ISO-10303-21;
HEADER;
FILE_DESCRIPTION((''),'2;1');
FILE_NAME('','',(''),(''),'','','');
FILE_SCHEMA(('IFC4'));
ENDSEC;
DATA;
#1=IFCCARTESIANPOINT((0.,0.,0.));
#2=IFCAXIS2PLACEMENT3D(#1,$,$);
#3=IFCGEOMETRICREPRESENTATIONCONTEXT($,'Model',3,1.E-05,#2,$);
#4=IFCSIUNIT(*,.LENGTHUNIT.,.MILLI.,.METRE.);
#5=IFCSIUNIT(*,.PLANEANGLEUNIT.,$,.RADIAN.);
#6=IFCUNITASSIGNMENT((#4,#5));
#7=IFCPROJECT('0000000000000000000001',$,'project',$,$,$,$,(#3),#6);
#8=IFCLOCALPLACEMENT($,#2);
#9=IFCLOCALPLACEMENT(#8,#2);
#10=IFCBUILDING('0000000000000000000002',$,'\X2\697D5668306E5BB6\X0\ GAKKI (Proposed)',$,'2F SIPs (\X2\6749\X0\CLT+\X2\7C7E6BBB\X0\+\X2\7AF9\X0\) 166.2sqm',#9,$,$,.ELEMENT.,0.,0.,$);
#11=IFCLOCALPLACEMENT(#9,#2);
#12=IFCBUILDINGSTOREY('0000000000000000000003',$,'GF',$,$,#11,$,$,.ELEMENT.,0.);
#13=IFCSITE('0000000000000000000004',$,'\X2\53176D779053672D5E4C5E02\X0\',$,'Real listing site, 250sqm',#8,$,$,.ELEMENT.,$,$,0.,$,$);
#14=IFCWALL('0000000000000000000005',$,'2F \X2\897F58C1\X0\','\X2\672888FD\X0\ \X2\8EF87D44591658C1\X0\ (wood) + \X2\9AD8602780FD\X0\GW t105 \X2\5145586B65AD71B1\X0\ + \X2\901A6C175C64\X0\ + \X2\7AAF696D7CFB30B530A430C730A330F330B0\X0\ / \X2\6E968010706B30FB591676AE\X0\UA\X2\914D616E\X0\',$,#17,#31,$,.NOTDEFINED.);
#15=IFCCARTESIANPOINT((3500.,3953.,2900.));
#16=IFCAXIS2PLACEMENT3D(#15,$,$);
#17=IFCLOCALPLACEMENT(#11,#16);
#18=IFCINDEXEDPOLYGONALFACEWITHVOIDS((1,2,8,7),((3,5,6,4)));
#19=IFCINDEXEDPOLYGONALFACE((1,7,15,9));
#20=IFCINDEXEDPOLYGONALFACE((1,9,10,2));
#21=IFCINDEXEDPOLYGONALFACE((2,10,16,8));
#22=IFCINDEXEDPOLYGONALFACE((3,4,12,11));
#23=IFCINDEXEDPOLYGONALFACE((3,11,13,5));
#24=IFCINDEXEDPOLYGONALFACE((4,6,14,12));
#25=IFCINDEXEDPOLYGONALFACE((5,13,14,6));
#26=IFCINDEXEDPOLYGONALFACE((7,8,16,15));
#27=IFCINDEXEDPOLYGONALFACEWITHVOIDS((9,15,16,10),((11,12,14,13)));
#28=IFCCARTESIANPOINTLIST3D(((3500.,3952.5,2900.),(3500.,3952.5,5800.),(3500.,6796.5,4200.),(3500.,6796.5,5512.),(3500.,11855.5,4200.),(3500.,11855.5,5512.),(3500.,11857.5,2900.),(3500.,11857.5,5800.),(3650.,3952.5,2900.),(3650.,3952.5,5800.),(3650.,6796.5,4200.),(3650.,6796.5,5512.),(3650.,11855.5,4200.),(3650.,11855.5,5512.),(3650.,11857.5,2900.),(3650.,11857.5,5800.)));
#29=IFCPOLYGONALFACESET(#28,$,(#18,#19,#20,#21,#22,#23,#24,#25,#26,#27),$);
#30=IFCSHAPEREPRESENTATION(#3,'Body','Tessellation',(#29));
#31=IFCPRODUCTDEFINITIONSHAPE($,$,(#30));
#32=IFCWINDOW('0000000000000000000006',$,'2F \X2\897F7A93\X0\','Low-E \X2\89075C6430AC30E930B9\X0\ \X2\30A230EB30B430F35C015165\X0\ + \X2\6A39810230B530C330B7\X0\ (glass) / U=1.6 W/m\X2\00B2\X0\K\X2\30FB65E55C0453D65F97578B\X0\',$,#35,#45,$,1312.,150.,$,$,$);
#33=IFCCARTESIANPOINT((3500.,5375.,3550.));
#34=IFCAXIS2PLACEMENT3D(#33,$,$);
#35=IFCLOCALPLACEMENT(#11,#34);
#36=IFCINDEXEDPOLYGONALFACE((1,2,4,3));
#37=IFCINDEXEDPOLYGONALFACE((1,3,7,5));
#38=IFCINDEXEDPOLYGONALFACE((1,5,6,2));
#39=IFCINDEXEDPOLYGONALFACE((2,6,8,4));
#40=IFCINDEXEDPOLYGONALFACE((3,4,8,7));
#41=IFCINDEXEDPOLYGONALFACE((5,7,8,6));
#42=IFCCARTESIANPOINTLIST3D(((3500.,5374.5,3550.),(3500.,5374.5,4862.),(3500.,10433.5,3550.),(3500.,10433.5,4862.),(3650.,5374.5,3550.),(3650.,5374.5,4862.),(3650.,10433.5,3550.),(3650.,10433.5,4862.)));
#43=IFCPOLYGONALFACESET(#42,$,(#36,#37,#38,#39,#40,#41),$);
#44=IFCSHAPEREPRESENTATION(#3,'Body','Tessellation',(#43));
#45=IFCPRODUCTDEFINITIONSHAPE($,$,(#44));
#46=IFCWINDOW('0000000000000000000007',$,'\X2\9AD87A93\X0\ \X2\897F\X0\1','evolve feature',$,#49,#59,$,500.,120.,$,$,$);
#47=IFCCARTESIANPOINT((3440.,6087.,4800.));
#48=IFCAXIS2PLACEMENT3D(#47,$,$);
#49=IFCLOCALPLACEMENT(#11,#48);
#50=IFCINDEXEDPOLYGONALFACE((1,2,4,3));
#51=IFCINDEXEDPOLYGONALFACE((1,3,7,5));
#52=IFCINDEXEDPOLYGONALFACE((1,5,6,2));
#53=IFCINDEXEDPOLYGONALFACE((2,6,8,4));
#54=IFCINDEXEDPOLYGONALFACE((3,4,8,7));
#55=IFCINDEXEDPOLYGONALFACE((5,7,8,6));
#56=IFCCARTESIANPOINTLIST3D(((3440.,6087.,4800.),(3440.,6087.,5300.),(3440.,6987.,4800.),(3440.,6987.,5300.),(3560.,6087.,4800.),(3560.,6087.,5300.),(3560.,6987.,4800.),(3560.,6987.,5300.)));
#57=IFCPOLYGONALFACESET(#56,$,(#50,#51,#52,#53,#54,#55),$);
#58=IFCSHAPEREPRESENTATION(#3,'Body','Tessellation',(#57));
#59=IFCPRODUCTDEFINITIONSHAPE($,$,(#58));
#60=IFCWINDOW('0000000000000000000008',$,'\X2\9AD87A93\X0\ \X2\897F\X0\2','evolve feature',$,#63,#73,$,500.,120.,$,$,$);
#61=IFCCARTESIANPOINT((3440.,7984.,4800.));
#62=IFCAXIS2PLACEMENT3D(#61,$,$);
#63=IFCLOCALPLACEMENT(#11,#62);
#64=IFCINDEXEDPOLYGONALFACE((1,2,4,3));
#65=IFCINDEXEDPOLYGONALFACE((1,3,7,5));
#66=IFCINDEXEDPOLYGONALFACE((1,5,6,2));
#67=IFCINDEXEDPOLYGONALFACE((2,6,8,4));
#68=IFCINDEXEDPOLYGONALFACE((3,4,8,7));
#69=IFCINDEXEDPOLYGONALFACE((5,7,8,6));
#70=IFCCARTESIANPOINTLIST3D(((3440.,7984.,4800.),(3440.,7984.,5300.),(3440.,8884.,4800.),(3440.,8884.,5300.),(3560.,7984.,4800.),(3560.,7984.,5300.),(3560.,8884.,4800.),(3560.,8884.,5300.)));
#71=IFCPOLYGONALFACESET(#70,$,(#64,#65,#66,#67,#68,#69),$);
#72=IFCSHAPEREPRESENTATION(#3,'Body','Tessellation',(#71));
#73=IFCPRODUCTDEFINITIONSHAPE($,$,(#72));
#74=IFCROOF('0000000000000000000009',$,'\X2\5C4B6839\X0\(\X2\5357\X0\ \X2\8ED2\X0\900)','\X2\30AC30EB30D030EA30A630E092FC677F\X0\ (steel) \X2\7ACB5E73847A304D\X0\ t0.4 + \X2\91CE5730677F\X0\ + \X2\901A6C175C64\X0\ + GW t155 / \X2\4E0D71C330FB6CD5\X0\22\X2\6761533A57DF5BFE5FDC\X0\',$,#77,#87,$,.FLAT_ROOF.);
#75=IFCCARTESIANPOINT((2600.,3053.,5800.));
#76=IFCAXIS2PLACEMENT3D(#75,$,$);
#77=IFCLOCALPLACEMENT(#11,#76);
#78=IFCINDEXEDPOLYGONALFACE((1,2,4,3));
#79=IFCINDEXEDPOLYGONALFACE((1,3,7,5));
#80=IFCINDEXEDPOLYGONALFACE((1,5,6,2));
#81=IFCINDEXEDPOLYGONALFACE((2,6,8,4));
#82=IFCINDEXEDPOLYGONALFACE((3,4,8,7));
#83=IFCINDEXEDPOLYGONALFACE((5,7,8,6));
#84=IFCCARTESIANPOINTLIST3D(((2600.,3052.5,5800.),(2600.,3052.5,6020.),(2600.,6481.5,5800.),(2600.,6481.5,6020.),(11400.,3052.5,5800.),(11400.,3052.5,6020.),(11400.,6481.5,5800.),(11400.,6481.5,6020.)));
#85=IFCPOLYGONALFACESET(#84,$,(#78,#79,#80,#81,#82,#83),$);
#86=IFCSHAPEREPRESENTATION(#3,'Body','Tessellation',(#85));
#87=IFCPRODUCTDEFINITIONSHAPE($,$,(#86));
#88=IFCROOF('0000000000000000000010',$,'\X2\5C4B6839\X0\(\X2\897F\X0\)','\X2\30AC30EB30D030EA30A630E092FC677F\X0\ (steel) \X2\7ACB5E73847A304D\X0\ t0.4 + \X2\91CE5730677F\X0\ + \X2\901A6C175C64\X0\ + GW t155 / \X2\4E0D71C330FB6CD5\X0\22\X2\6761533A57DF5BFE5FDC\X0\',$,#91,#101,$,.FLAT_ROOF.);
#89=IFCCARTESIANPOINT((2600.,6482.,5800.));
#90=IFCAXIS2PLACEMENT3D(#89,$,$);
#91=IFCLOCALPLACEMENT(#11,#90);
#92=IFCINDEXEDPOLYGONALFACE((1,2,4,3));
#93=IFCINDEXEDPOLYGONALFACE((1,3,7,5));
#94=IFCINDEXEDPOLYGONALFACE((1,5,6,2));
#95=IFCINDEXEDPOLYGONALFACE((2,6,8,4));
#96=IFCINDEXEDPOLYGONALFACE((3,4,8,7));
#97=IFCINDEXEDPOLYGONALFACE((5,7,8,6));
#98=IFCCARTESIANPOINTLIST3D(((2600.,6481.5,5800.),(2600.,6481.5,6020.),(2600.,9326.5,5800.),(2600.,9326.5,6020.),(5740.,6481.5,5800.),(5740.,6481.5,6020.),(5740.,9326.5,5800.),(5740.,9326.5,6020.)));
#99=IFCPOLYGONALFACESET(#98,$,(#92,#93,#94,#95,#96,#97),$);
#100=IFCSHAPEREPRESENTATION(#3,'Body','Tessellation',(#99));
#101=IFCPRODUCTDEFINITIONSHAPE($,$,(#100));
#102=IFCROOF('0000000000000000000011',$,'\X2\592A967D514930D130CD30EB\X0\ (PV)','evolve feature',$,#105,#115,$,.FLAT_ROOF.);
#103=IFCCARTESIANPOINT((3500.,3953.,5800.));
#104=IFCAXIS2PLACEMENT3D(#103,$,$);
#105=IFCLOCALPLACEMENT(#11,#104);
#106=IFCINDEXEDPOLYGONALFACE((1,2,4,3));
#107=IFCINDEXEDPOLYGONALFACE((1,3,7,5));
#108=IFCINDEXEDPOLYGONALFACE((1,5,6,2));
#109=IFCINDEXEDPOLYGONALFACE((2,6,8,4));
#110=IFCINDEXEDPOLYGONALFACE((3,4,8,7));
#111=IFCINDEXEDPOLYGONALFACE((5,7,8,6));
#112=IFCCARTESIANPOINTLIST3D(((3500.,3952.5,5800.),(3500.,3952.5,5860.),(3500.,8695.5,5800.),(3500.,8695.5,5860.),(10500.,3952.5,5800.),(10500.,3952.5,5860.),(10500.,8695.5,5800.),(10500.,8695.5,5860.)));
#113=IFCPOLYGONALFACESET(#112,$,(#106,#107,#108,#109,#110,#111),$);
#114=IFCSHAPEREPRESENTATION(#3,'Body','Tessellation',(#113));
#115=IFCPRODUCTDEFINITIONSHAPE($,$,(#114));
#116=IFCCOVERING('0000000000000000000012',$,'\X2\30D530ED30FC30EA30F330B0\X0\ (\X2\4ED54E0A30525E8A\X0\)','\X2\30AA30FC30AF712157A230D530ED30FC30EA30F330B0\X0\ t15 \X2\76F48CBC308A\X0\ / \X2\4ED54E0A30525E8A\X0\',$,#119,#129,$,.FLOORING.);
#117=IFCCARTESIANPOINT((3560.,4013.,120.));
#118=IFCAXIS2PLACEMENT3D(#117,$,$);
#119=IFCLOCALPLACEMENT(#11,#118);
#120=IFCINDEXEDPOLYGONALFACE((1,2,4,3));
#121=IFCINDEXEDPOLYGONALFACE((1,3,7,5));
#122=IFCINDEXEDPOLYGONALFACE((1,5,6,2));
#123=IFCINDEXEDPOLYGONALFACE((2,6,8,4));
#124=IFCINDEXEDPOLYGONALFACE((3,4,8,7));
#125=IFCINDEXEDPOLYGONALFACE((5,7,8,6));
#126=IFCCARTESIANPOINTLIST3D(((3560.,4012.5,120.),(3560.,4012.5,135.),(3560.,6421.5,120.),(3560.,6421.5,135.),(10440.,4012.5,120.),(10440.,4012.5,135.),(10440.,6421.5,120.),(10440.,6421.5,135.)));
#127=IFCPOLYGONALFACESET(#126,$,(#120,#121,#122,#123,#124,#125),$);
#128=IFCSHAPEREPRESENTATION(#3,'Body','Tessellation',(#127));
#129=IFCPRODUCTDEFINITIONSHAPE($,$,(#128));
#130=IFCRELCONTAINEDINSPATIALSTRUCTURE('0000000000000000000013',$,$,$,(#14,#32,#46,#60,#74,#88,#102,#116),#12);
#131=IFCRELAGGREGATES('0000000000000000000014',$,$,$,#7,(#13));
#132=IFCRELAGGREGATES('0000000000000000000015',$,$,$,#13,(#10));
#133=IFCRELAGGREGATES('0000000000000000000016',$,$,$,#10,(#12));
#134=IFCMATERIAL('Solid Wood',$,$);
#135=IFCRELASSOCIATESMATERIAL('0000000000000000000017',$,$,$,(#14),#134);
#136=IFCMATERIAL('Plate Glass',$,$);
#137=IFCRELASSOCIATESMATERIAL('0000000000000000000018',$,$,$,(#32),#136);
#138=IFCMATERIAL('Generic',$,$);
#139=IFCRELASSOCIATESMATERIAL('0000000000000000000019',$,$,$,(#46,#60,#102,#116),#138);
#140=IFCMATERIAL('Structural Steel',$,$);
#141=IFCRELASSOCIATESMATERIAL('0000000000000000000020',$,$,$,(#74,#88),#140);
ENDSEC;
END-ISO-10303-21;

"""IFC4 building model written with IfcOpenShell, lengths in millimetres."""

from ifc_helpers import new_model, si_unit, frame, frame_2d, origin, place, context, project, spatial, rectangle, extrude, material, element, fill, save


model = new_model("IFC4")

# Units and contexts
model_context = context("Model", 3, precision=1e-05, world=origin())
ifc_project = project(units=[si_unit("LENGTHUNIT", "METRE", prefix="MILLI"), si_unit("PLANEANGLEUNIT", "RADIAN")], contexts=[model_context])

# Site, building, storey
site_placement = place(None, origin())
site = spatial("IfcSite", under=ifc_project, at=site_placement, Name="北海道札幌市", ObjectType="Real listing site, 250sqm", CompositionType="ELEMENT", RefElevation=0.0)
building_placement = place(site_placement, origin())
building = spatial("IfcBuilding", under=site, at=building_placement, Name="楽器の家 GAKKI (Proposed)", ObjectType="2F SIPs (杉CLT+籾殻+竹) 166.2sqm", CompositionType="ELEMENT", ElevationOfRefHeight=0.0, ElevationOfTerrain=0.0)
storey_placement = place(building_placement, origin())
storey = spatial("IfcBuildingStorey", under=building, at=storey_placement, Name="GF", CompositionType="ELEMENT", Elevation=0.0)

# Shared definitions
ifc_material_1 = material(Name="Solid Wood")
ifc_material_2 = material(Name="Generic")

# Shared definitions
ifc_material_3 = material(Name="Plate Glass")

# Wall, openings, windows
wall_1_placement = place(storey_placement, frame((3500.0, 3953.0, 2900.0)))
wall_1 = element("IfcWall", 1, at=wall_1_placement, inside=storey, material=ifc_material_1, Name="2F 西壁", Description="木製 軸組外壁 (wood) + 高性能GW t105 充填断熱 + 通気層 + 窯業系サイディング / 準耐火・外皮UA配慮", PredefinedType="NOTDEFINED", context=model_context, shape_type="SweptSolid", body=[
    extrude(rectangle(XDim=150.0, YDim=7905.0, at=frame_2d((75.0, 3952.0))), frame((3500.0, 3953.0, 2900.0)), (0.0, 0.0, 1.0), 2900.0),
])
opening_1_placement = place(storey_placement, frame((3500.0, 5375.0, 3550.0)))
opening_1 = element("IfcOpeningElement", 2, at=opening_1_placement, cuts=wall_1, PredefinedType="NOTDEFINED", context=model_context, shape_type="SweptSolid", body=[
    extrude(rectangle(XDim=150.0, YDim=5059.0, at=frame_2d((75.0, 2529.0))), frame((3500.0, 5375.0, 3550.0)), (0.0, 0.0, 1.0), 1312.0),
])
opening_2_placement = place(storey_placement, frame((3440.0, 6087.0, 4800.0)))
opening_2 = element("IfcOpeningElement", 3, at=opening_2_placement, cuts=wall_1, PredefinedType="NOTDEFINED", context=model_context, shape_type="SweptSolid", body=[
    extrude(rectangle(XDim=120.0, YDim=900.0, at=frame_2d((60.0, 450.0))), frame((3440.0, 6087.0, 4800.0)), (0.0, 0.0, 1.0), 500.0),
])
opening_3_placement = place(storey_placement, frame((3440.0, 7984.0, 4800.0)))
opening_3 = element("IfcOpeningElement", 4, at=opening_3_placement, cuts=wall_1, PredefinedType="NOTDEFINED", context=model_context, shape_type="SweptSolid", body=[
    extrude(rectangle(XDim=120.0, YDim=900.0, at=frame_2d((60.0, 450.0))), frame((3440.0, 7984.0, 4800.0)), (0.0, 0.0, 1.0), 500.0),
])
window_1_placement = place(storey_placement, frame((3500.0, 5375.0, 3550.0)))
window_1 = element("IfcWindow", 5, at=window_1_placement, inside=storey, material=ifc_material_3, Name="2F 西窓", Description="Low-E 複層ガラス アルゴン封入 + 樹脂サッシ (glass) / U=1.6 W/m²K・日射取得型", OverallHeight=1312.0, OverallWidth=150.0, context=model_context, shape_type="SweptSolid", body=[
    extrude(rectangle(XDim=150.0, YDim=5059.0, at=frame_2d((75.0, 2529.0))), frame((3500.0, 5375.0, 3550.0)), (0.0, 0.0, 1.0), 1312.0),
])
fill(opening_1, window_1)
window_2_placement = place(storey_placement, frame((3440.0, 6087.0, 4800.0)))
window_2 = element("IfcWindow", 6, at=window_2_placement, inside=storey, material=ifc_material_2, Name="高窓 西1", Description="evolve feature", OverallHeight=500.0, OverallWidth=120.0, context=model_context, shape_type="SweptSolid", body=[
    extrude(rectangle(XDim=120.0, YDim=900.0, at=frame_2d((60.0, 450.0))), frame((3440.0, 6087.0, 4800.0)), (0.0, 0.0, 1.0), 500.0),
])
fill(opening_2, window_2)
window_3_placement = place(storey_placement, frame((3440.0, 7984.0, 4800.0)))
window_3 = element("IfcWindow", 7, at=window_3_placement, inside=storey, material=ifc_material_2, Name="高窓 西2", Description="evolve feature", OverallHeight=500.0, OverallWidth=120.0, context=model_context, shape_type="SweptSolid", body=[
    extrude(rectangle(XDim=120.0, YDim=900.0, at=frame_2d((60.0, 450.0))), frame((3440.0, 7984.0, 4800.0)), (0.0, 0.0, 1.0), 500.0),
])
fill(opening_3, window_3)

# Roofs
ifc_material_4 = material(Name="Structural Steel")
roof_1_placement = place(storey_placement, frame((2600.0, 3053.0, 5800.0)))
element("IfcRoof", 8, at=roof_1_placement, inside=storey, material=ifc_material_4, Name="屋根(南 軒900)", Description="ガルバリウム鋼板 (steel) 立平葺き t0.4 + 野地板 + 通気層 + GW t155 / 不燃・法22条区域対応", PredefinedType="FLAT_ROOF", context=model_context, shape_type="SweptSolid", body=[
    extrude(rectangle(XDim=8800.0, YDim=3429.0, at=frame_2d((4400.0, 1714.0))), frame((2600.0, 3053.0, 5800.0)), (0.0, 0.0, 1.0), 220.0),
])
roof_2_placement = place(storey_placement, frame((2600.0, 6482.0, 5800.0)))
element("IfcRoof", 9, at=roof_2_placement, inside=storey, material=ifc_material_4, Name="屋根(西)", Description="ガルバリウム鋼板 (steel) 立平葺き t0.4 + 野地板 + 通気層 + GW t155 / 不燃・法22条区域対応", PredefinedType="FLAT_ROOF", context=model_context, shape_type="SweptSolid", body=[
    extrude(rectangle(XDim=3140.0, YDim=2845.0, at=frame_2d((1570.0, 1422.0))), frame((2600.0, 6482.0, 5800.0)), (0.0, 0.0, 1.0), 220.0),
])
roof_3_placement = place(storey_placement, frame((3500.0, 3953.0, 5800.0)))
element("IfcRoof", 10, at=roof_3_placement, inside=storey, material=ifc_material_2, Name="太陽光パネル (PV)", Description="evolve feature", PredefinedType="FLAT_ROOF", context=model_context, shape_type="SweptSolid", body=[
    extrude(rectangle(XDim=7000.0, YDim=4743.0, at=frame_2d((3500.0, 2371.0))), frame((3500.0, 3953.0, 5800.0)), (0.0, 0.0, 1.0), 60.0),
])

# Covering
covering_placement = place(storey_placement, frame((3560.0, 4013.0, 120.0)))
element("IfcCovering", 11, at=covering_placement, inside=storey, material=ifc_material_2, Name="フローリング (仕上げ床)", Description="オーク無垢フローリング t15 直貼り / 仕上げ床", PredefinedType="FLOORING", context=model_context, shape_type="SweptSolid", body=[
    extrude(rectangle(XDim=6880.0, YDim=2409.0, at=frame_2d((3440.0, 1204.0))), frame((3560.0, 4013.0, 120.0)), (0.0, 0.0, 1.0), 15.0),
])

save(model, "model.ifc")
